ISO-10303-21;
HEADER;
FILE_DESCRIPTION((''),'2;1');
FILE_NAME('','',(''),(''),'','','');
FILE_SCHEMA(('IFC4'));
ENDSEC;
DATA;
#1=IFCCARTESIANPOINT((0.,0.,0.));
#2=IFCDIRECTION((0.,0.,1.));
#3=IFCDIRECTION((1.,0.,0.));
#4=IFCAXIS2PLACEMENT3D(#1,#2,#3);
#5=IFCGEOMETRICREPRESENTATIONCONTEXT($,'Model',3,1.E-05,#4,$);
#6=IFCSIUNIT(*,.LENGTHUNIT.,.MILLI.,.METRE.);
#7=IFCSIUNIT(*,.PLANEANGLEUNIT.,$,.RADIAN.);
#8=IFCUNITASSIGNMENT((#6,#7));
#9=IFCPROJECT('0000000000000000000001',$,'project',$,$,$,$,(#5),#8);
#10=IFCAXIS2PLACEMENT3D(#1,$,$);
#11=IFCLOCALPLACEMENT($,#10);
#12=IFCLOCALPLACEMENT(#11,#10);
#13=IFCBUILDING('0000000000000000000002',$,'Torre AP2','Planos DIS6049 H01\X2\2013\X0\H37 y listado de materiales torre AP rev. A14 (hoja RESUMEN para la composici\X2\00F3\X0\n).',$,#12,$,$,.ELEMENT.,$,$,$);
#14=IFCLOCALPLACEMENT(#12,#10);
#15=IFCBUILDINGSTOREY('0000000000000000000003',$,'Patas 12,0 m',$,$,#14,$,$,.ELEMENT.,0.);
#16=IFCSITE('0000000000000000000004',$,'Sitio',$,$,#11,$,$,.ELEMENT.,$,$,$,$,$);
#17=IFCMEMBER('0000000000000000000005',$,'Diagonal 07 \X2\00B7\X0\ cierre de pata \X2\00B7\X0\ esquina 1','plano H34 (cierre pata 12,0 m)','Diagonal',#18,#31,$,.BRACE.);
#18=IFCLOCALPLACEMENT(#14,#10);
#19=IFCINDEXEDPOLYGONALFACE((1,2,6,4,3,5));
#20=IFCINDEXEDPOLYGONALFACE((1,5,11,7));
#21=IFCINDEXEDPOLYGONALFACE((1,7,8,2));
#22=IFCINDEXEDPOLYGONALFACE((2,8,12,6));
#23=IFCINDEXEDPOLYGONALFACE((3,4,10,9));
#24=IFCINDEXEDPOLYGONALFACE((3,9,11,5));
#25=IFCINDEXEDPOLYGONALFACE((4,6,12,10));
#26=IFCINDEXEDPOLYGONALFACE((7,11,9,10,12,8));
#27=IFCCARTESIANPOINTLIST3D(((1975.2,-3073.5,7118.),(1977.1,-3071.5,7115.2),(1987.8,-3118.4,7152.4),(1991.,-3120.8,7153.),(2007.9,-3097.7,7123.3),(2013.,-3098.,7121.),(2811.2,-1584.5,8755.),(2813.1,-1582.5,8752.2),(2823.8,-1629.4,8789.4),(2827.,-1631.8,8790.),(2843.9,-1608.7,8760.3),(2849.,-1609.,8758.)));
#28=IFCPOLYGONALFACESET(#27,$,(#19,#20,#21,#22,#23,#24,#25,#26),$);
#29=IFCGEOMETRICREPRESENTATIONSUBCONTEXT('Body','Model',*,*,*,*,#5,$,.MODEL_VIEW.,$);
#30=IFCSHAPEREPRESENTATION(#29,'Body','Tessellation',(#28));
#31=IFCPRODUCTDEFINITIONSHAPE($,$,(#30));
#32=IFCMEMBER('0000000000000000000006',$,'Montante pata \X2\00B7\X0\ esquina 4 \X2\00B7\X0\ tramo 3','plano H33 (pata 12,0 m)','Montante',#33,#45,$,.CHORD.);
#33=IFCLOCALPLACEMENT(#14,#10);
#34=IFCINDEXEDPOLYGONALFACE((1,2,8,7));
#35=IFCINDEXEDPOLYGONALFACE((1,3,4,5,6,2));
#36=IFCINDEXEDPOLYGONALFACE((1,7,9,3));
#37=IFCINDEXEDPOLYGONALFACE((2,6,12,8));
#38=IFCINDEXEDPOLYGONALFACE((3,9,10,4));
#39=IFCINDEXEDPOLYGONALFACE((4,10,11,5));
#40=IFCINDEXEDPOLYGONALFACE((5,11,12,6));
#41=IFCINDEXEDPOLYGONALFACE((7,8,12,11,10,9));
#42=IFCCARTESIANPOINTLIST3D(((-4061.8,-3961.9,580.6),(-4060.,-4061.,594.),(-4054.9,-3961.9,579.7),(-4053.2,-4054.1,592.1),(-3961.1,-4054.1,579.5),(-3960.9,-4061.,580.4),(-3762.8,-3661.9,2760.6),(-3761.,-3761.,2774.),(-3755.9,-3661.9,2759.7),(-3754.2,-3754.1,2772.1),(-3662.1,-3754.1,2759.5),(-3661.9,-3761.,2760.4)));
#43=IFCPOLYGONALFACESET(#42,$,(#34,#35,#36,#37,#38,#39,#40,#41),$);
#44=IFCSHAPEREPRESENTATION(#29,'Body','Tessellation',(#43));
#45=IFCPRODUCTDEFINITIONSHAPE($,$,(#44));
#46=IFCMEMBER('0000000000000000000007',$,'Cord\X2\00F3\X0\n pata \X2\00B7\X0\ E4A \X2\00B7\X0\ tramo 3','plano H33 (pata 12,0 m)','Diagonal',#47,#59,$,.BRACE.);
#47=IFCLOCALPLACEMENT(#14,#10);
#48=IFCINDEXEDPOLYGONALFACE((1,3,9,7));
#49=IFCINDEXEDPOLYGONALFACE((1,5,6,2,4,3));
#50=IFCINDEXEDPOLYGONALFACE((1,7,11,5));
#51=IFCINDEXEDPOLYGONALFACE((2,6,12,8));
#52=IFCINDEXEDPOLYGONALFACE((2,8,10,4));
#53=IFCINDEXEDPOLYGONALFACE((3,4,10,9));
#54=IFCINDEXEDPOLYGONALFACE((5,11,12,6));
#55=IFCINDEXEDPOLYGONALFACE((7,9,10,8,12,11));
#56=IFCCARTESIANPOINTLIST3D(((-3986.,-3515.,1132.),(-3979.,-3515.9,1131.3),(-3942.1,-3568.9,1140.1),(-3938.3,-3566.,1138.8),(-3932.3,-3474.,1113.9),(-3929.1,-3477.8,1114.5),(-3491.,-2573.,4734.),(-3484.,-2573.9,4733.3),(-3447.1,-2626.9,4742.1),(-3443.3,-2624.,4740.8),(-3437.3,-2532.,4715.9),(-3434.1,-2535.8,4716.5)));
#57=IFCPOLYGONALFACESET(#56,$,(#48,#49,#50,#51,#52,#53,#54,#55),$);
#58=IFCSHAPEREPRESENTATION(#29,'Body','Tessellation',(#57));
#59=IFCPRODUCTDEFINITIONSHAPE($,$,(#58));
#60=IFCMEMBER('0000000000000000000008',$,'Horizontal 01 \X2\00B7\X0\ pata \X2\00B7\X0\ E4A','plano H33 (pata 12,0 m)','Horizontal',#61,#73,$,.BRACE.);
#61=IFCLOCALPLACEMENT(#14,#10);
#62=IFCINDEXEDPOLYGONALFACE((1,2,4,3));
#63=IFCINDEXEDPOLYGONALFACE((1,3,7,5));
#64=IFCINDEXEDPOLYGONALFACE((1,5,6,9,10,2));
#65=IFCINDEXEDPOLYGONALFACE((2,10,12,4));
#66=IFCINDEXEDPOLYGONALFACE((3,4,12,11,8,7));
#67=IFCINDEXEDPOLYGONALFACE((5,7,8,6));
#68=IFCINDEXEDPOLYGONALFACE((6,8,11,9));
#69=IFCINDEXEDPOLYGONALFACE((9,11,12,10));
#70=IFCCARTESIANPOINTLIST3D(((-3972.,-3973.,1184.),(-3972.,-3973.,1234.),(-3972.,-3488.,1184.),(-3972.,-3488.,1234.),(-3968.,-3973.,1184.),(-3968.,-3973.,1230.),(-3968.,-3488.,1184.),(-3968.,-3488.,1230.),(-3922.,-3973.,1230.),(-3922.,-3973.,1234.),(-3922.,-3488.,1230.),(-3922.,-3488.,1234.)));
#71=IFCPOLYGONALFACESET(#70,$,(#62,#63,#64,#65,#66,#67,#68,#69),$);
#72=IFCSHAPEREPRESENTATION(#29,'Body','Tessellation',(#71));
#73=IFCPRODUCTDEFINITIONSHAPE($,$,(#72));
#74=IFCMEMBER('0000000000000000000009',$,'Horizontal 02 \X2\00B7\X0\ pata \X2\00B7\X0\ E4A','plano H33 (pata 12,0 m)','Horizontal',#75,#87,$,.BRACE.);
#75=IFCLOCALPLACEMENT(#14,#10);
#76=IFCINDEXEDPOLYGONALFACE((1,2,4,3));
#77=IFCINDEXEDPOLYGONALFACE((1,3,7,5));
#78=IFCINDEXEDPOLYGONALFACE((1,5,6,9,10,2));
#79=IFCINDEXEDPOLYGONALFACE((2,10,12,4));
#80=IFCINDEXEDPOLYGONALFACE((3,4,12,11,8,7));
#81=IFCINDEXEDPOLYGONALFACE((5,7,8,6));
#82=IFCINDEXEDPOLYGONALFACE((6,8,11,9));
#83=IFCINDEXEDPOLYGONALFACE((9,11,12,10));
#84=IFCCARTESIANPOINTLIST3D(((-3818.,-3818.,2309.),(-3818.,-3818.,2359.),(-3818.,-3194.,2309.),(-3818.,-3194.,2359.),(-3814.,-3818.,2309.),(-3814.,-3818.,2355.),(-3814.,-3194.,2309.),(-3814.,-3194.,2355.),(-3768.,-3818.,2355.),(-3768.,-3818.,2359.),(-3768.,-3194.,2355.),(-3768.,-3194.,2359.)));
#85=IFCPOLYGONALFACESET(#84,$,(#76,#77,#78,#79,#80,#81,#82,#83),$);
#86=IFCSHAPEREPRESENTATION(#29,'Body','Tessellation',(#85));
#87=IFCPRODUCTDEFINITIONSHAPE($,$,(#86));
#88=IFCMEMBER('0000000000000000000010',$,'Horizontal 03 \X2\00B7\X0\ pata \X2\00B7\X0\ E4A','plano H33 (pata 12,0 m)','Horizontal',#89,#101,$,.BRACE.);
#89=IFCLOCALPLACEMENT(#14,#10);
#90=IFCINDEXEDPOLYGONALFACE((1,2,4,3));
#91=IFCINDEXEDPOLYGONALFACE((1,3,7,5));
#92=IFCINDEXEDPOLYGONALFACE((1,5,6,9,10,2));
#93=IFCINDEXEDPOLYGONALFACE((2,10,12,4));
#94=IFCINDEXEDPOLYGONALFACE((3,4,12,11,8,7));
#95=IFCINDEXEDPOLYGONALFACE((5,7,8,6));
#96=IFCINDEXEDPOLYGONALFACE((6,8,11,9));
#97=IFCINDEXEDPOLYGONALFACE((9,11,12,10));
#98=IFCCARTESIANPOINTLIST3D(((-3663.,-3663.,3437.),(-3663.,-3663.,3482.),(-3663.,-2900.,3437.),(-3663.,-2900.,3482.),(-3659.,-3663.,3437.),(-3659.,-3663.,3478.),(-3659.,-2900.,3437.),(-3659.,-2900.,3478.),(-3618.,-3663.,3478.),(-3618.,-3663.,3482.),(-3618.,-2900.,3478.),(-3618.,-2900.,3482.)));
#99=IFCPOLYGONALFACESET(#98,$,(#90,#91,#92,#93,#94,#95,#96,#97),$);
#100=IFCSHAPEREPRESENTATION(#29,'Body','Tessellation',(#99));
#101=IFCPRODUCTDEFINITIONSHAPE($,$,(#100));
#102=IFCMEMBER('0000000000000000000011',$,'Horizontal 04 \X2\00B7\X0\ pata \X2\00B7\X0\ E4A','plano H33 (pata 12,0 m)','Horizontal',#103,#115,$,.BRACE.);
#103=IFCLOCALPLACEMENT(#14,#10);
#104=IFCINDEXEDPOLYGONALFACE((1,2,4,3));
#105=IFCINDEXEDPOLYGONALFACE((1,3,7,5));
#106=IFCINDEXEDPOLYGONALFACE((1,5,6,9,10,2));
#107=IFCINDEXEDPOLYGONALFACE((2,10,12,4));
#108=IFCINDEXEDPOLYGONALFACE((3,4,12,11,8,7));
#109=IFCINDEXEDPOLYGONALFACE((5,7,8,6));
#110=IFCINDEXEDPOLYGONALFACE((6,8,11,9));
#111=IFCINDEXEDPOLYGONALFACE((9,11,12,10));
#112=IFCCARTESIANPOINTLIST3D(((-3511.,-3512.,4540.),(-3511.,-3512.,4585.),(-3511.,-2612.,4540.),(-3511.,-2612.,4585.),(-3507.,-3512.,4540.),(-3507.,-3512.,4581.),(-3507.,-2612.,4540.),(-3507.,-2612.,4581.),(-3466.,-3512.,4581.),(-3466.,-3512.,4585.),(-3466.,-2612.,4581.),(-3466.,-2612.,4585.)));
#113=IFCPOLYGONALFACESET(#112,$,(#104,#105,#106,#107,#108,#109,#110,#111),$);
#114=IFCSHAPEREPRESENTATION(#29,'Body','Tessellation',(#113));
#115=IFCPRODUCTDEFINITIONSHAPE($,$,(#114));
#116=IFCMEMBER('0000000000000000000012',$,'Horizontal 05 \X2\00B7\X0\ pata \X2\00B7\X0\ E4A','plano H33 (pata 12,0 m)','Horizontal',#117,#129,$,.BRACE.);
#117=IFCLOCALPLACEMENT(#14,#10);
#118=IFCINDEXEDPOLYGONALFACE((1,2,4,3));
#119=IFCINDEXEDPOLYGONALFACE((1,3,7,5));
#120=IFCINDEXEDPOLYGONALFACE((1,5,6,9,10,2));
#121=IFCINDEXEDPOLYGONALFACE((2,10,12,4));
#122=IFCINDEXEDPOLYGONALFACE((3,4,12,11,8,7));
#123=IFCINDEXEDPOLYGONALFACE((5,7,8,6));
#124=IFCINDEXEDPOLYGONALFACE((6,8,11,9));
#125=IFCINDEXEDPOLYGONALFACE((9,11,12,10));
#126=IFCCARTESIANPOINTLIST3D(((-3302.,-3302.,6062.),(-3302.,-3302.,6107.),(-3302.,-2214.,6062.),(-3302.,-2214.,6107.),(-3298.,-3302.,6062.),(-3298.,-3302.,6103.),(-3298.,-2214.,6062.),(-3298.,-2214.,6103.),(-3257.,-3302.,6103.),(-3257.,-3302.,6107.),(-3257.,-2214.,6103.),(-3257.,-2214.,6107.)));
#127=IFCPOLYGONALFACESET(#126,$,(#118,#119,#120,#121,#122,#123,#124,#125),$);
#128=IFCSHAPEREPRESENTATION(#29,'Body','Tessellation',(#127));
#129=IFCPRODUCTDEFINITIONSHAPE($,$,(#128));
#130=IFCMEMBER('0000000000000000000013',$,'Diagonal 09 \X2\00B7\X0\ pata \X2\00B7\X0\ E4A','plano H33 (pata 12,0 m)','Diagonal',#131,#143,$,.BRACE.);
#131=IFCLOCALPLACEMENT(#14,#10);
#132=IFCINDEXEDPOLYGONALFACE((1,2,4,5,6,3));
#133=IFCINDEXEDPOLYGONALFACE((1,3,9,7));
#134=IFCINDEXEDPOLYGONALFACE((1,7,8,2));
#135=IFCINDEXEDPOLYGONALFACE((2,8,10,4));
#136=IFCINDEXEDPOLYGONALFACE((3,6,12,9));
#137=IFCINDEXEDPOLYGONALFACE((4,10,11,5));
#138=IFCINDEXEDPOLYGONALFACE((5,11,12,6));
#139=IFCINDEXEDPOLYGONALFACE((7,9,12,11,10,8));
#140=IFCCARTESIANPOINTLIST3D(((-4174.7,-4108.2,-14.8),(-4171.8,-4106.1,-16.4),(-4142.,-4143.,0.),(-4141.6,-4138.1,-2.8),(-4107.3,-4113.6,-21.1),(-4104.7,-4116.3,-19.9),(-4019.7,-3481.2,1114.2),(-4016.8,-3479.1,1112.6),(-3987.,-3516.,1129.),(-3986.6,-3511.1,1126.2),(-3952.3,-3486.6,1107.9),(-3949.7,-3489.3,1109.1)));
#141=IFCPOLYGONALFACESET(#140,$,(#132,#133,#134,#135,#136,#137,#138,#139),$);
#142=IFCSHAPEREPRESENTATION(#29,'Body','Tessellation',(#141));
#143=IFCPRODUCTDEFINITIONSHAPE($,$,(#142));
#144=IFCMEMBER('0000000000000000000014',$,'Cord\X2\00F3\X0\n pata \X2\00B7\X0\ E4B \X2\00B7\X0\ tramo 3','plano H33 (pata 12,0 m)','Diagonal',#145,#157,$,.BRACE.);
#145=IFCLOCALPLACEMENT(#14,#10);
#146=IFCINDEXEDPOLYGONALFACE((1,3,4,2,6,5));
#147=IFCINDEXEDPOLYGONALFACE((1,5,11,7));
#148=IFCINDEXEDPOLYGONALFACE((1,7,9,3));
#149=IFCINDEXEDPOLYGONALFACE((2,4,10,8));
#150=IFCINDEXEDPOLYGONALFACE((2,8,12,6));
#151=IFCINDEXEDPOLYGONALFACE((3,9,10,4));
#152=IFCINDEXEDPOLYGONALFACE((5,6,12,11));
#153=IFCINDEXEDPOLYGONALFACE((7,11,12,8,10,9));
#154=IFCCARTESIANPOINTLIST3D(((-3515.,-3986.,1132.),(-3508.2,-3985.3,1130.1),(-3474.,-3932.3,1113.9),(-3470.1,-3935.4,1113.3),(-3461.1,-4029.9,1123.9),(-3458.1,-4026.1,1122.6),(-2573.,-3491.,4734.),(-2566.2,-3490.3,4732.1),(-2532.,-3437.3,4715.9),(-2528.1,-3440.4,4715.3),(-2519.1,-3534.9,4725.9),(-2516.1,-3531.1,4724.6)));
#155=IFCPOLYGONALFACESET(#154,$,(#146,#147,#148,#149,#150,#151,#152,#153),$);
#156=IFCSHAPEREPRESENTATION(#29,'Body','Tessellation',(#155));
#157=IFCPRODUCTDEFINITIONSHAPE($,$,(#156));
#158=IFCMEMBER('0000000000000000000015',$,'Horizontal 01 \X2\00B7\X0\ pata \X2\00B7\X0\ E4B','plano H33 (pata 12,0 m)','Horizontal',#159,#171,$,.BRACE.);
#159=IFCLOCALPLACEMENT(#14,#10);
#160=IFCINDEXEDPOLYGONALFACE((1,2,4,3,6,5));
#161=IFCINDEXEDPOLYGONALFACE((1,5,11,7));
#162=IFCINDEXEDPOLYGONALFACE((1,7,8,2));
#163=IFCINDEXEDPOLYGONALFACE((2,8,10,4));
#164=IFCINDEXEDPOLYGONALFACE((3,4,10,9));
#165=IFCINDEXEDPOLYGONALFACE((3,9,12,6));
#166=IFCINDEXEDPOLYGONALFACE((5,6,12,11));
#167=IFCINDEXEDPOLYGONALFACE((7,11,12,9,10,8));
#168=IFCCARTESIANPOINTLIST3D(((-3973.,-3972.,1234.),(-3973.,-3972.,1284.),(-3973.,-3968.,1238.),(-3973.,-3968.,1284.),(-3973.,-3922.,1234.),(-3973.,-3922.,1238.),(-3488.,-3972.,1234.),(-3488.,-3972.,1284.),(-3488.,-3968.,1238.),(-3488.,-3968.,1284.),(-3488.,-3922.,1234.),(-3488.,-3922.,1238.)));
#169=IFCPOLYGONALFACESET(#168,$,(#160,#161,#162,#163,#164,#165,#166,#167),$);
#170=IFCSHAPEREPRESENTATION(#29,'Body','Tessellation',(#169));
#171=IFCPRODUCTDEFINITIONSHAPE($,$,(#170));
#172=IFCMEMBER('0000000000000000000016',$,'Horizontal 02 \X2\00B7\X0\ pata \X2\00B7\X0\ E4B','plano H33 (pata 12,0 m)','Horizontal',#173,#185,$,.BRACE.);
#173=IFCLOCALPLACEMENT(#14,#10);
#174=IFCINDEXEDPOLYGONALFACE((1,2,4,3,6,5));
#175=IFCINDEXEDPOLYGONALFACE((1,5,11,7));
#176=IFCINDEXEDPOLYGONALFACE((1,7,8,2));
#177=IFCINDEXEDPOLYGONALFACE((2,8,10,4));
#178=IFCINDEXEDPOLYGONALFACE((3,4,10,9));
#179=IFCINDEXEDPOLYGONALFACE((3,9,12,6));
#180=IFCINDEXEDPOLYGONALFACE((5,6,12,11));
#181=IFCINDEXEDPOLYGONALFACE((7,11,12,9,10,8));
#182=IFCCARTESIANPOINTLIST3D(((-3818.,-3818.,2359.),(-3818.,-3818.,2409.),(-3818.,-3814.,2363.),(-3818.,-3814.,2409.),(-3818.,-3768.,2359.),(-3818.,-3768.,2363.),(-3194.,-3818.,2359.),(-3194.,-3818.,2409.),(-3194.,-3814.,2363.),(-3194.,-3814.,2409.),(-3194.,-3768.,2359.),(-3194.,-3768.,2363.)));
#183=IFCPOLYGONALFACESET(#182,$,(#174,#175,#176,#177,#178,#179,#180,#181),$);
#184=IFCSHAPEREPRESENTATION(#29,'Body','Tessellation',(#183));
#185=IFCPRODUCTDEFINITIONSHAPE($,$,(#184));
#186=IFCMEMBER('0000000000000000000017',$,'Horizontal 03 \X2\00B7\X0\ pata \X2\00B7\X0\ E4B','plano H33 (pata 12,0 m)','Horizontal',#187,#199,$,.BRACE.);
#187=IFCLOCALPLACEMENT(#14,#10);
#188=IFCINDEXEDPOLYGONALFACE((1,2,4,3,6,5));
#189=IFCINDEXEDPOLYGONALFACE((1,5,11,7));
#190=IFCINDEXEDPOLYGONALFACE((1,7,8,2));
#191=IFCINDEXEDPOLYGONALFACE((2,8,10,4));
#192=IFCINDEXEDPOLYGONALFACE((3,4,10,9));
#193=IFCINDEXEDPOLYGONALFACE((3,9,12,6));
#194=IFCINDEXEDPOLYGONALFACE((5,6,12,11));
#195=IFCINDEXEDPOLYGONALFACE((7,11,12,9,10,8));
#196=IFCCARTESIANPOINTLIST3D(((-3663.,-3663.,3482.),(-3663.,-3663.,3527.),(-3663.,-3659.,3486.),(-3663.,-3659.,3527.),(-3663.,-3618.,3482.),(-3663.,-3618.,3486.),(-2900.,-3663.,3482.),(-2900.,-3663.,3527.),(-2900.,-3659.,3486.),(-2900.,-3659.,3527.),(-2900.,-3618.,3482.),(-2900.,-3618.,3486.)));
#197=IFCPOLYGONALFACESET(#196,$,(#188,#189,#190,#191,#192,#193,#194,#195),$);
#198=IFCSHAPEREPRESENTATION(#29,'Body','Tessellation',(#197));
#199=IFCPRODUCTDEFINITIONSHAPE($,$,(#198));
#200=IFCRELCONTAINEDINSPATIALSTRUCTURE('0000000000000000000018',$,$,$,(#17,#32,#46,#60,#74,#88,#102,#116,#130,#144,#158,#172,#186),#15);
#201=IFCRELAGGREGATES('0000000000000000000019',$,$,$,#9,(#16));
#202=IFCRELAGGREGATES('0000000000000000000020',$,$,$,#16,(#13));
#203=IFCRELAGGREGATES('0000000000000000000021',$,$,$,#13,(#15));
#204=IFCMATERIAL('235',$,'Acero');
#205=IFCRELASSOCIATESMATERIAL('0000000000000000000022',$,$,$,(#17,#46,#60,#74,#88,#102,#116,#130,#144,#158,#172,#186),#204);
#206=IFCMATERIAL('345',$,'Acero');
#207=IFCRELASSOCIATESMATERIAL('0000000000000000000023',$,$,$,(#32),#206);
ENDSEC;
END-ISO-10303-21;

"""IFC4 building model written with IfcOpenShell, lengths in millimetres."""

from ifc_helpers import new_model, si_unit, frame, frame_2d, origin, origin_with_axes, place, context, subcontext, project, spatial, l_section, extrude, material, element, save


model = new_model("IFC4")

# Units and contexts
model_context = context("Model", 3, precision=1e-05, world=origin_with_axes())
body_context = subcontext(model_context, "Body", "Model", "MODEL_VIEW")
ifc_project = project(units=[si_unit("LENGTHUNIT", "METRE", prefix="MILLI"), si_unit("PLANEANGLEUNIT", "RADIAN")], contexts=[model_context])

# Site, building, storey
site_placement = place(None, origin())
site = spatial("IfcSite", under=ifc_project, at=site_placement, Name="Sitio", CompositionType="ELEMENT")
building_placement = place(site_placement, origin())
building = spatial("IfcBuilding", under=site, at=building_placement, Name="Torre AP2", Description="Planos DIS6049 H01–H37 y listado de materiales torre AP rev. A14 (hoja RESUMEN para la composición).", CompositionType="ELEMENT")
storey_placement = place(building_placement, origin())
storey = spatial("IfcBuildingStorey", under=building, at=storey_placement, Name="Patas 12,0 m", CompositionType="ELEMENT", Elevation=0.0)

# Members
ifc_material_1 = material(Name="235", Category="Acero")
member_1_placement = place(storey_placement, frame((2013.0, -3098.0, 7121.0), z_axis=(0.353407, 0.629454, 0.692019), x_axis=(-0.797058, 0.589858, -0.12948)))
element("IfcMember", 1, at=member_1_placement, inside=storey, material=ifc_material_1, Name="Diagonal 07 · cierre de pata · esquina 1", Description="plano H34 (cierre pata 12,0 m)", ObjectType="Diagonal", PredefinedType="BRACE", context=body_context, shape_type="SweptSolid", body=[
    extrude(l_section(Depth=45.0, Width=45.0, Thickness=4.0, at=frame_2d((22.5, 22.5))), None, (0.0, 0.0, 1.0), 2365.5),
])
ifc_material_2 = material(Name="345", Category="Acero")
member_2_placement = place(storey_placement, frame((-3761.0, -3761.0, 2774.0), z_axis=(-0.134638, -0.135089, -0.981643), x_axis=(-0.018356, 0.990834, -0.133836)))
element("IfcMember", 2, at=member_2_placement, inside=storey, material=ifc_material_2, Name="Montante pata · esquina 4 · tramo 3", Description="plano H33 (pata 12,0 m)", ObjectType="Montante", PredefinedType="CHORD", context=body_context, shape_type="SweptSolid", body=[
    extrude(l_section(Depth=100.0, Width=100.0, Thickness=7.0, at=frame_2d((50.0, 50.0))), None, (0.0, 0.0, 1.0), 2220.8),
])
member_3_placement = place(storey_placement, frame((-3491.0, -2573.0, 4734.0), z_axis=(-0.131793, -0.250805, -0.959024), x_axis=(0.767633, 0.586303, -0.258822)))
element("IfcMember", 3, at=member_3_placement, inside=storey, material=ifc_material_1, Name="Cordón pata · E4A · tramo 3", Description="plano H33 (pata 12,0 m)", ObjectType="Diagonal", PredefinedType="BRACE", context=body_context, shape_type="SweptSolid", body=[
    extrude(l_section(Depth=70.0, Width=70.0, Thickness=5.0, at=frame_2d((35.0, 35.0))), None, (0.0, 0.0, 1.0), 3755.9),
])
member_4_placement = place(storey_placement, frame((-3972.0, -3973.0, 1234.0), z_axis=(0.0, 1.0, 0.0), x_axis=(1.0, 0.0, 0.0)))
element("IfcMember", 4, at=member_4_placement, inside=storey, material=ifc_material_1, Name="Horizontal 01 · pata · E4A", Description="plano H33 (pata 12,0 m)", ObjectType="Horizontal", PredefinedType="BRACE", context=body_context, shape_type="SweptSolid", body=[
    extrude(l_section(Depth=50.0, Width=50.0, Thickness=4.0, at=frame_2d((25.0, 25.0))), None, (0.0, 0.0, 1.0), 485.0),
])
member_5_placement = place(storey_placement, frame((-3818.0, -3818.0, 2359.0), z_axis=(0.0, 1.0, 0.0), x_axis=(1.0, 0.0, 0.0)))
element("IfcMember", 5, at=member_5_placement, inside=storey, material=ifc_material_1, Name="Horizontal 02 · pata · E4A", Description="plano H33 (pata 12,0 m)", ObjectType="Horizontal", PredefinedType="BRACE", context=body_context, shape_type="SweptSolid", body=[
    extrude(l_section(Depth=50.0, Width=50.0, Thickness=4.0, at=frame_2d((25.0, 25.0))), None, (0.0, 0.0, 1.0), 624.0),
])
member_6_placement = place(storey_placement, frame((-3663.0, -3663.0, 3482.0), z_axis=(0.0, 1.0, 0.0), x_axis=(1.0, 0.0, 0.0)))
element("IfcMember", 6, at=member_6_placement, inside=storey, material=ifc_material_1, Name="Horizontal 03 · pata · E4A", Description="plano H33 (pata 12,0 m)", ObjectType="Horizontal", PredefinedType="BRACE", context=body_context, shape_type="SweptSolid", body=[
    extrude(l_section(Depth=45.0, Width=45.0, Thickness=4.0, at=frame_2d((22.5, 22.5))), None, (0.0, 0.0, 1.0), 763.0),
])
member_7_placement = place(storey_placement, frame((-3511.0, -3512.0, 4585.0), z_axis=(0.0, 1.0, 0.0), x_axis=(1.0, 0.0, 0.0)))
element("IfcMember", 7, at=member_7_placement, inside=storey, material=ifc_material_1, Name="Horizontal 04 · pata · E4A", Description="plano H33 (pata 12,0 m)", ObjectType="Horizontal", PredefinedType="BRACE", context=body_context, shape_type="SweptSolid", body=[
    extrude(l_section(Depth=45.0, Width=45.0, Thickness=4.0, at=frame_2d((22.5, 22.5))), None, (0.0, 0.0, 1.0), 900.0),
])
member_8_placement = place(storey_placement, frame((-3302.0, -3302.0, 6107.0), z_axis=(0.0, 1.0, 0.0), x_axis=(1.0, 0.0, 0.0)))
element("IfcMember", 8, at=member_8_placement, inside=storey, material=ifc_material_1, Name="Horizontal 05 · pata · E4A", Description="plano H33 (pata 12,0 m)", ObjectType="Horizontal", PredefinedType="BRACE", context=body_context, shape_type="SweptSolid", body=[
    extrude(l_section(Depth=45.0, Width=45.0, Thickness=4.0, at=frame_2d((22.5, 22.5))), None, (0.0, 0.0, 1.0), 1088.0),
])
member_9_placement = place(storey_placement, frame((-4142.0, -4143.0, 0.0), z_axis=(0.119168, 0.482052, 0.868001), x_axis=(0.746182, 0.53324, -0.398583)))
element("IfcMember", 9, at=member_9_placement, inside=storey, material=ifc_material_1, Name="Diagonal 09 · pata · E4A", Description="plano H33 (pata 12,0 m)", ObjectType="Diagonal", PredefinedType="BRACE", context=body_context, shape_type="SweptSolid", body=[
    extrude(l_section(Depth=50.0, Width=50.0, Thickness=4.0, at=frame_2d((25.0, 25.0))), None, (0.0, 0.0, 1.0), 1300.7),
])
member_10_placement = place(storey_placement, frame((-2573.0, -3491.0, 4734.0), z_axis=(-0.250805, -0.131793, -0.959024), x_axis=(0.586303, 0.767633, -0.258822)))
element("IfcMember", 10, at=member_10_placement, inside=storey, material=ifc_material_1, Name="Cordón pata · E4B · tramo 3", Description="plano H33 (pata 12,0 m)", ObjectType="Diagonal", PredefinedType="BRACE", context=body_context, shape_type="SweptSolid", body=[
    extrude(l_section(Depth=70.0, Width=70.0, Thickness=5.0, at=frame_2d((35.0, 35.0))), None, (0.0, 0.0, 1.0), 3755.9),
])
member_11_placement = place(storey_placement, frame((-3973.0, -3972.0, 1234.0), z_axis=(1.0, 0.0, 0.0), x_axis=(0.0, 1.0, 0.0)))
element("IfcMember", 11, at=member_11_placement, inside=storey, material=ifc_material_1, Name="Horizontal 01 · pata · E4B", Description="plano H33 (pata 12,0 m)", ObjectType="Horizontal", PredefinedType="BRACE", context=body_context, shape_type="SweptSolid", body=[
    extrude(l_section(Depth=50.0, Width=50.0, Thickness=4.0, at=frame_2d((25.0, 25.0))), None, (0.0, 0.0, 1.0), 485.0),
])
member_12_placement = place(storey_placement, frame((-3818.0, -3818.0, 2359.0), z_axis=(1.0, 0.0, 0.0), x_axis=(0.0, 1.0, 0.0)))
element("IfcMember", 12, at=member_12_placement, inside=storey, material=ifc_material_1, Name="Horizontal 02 · pata · E4B", Description="plano H33 (pata 12,0 m)", ObjectType="Horizontal", PredefinedType="BRACE", context=body_context, shape_type="SweptSolid", body=[
    extrude(l_section(Depth=50.0, Width=50.0, Thickness=4.0, at=frame_2d((25.0, 25.0))), None, (0.0, 0.0, 1.0), 624.0),
])
member_13_placement = place(storey_placement, frame((-3663.0, -3663.0, 3482.0), z_axis=(1.0, 0.0, 0.0), x_axis=(0.0, 1.0, 0.0)))
element("IfcMember", 13, at=member_13_placement, inside=storey, material=ifc_material_1, Name="Horizontal 03 · pata · E4B", Description="plano H33 (pata 12,0 m)", ObjectType="Horizontal", PredefinedType="BRACE", context=body_context, shape_type="SweptSolid", body=[
    extrude(l_section(Depth=45.0, Width=45.0, Thickness=4.0, at=frame_2d((22.5, 22.5))), None, (0.0, 0.0, 1.0), 763.0),
])

save(model, "model.ifc")
